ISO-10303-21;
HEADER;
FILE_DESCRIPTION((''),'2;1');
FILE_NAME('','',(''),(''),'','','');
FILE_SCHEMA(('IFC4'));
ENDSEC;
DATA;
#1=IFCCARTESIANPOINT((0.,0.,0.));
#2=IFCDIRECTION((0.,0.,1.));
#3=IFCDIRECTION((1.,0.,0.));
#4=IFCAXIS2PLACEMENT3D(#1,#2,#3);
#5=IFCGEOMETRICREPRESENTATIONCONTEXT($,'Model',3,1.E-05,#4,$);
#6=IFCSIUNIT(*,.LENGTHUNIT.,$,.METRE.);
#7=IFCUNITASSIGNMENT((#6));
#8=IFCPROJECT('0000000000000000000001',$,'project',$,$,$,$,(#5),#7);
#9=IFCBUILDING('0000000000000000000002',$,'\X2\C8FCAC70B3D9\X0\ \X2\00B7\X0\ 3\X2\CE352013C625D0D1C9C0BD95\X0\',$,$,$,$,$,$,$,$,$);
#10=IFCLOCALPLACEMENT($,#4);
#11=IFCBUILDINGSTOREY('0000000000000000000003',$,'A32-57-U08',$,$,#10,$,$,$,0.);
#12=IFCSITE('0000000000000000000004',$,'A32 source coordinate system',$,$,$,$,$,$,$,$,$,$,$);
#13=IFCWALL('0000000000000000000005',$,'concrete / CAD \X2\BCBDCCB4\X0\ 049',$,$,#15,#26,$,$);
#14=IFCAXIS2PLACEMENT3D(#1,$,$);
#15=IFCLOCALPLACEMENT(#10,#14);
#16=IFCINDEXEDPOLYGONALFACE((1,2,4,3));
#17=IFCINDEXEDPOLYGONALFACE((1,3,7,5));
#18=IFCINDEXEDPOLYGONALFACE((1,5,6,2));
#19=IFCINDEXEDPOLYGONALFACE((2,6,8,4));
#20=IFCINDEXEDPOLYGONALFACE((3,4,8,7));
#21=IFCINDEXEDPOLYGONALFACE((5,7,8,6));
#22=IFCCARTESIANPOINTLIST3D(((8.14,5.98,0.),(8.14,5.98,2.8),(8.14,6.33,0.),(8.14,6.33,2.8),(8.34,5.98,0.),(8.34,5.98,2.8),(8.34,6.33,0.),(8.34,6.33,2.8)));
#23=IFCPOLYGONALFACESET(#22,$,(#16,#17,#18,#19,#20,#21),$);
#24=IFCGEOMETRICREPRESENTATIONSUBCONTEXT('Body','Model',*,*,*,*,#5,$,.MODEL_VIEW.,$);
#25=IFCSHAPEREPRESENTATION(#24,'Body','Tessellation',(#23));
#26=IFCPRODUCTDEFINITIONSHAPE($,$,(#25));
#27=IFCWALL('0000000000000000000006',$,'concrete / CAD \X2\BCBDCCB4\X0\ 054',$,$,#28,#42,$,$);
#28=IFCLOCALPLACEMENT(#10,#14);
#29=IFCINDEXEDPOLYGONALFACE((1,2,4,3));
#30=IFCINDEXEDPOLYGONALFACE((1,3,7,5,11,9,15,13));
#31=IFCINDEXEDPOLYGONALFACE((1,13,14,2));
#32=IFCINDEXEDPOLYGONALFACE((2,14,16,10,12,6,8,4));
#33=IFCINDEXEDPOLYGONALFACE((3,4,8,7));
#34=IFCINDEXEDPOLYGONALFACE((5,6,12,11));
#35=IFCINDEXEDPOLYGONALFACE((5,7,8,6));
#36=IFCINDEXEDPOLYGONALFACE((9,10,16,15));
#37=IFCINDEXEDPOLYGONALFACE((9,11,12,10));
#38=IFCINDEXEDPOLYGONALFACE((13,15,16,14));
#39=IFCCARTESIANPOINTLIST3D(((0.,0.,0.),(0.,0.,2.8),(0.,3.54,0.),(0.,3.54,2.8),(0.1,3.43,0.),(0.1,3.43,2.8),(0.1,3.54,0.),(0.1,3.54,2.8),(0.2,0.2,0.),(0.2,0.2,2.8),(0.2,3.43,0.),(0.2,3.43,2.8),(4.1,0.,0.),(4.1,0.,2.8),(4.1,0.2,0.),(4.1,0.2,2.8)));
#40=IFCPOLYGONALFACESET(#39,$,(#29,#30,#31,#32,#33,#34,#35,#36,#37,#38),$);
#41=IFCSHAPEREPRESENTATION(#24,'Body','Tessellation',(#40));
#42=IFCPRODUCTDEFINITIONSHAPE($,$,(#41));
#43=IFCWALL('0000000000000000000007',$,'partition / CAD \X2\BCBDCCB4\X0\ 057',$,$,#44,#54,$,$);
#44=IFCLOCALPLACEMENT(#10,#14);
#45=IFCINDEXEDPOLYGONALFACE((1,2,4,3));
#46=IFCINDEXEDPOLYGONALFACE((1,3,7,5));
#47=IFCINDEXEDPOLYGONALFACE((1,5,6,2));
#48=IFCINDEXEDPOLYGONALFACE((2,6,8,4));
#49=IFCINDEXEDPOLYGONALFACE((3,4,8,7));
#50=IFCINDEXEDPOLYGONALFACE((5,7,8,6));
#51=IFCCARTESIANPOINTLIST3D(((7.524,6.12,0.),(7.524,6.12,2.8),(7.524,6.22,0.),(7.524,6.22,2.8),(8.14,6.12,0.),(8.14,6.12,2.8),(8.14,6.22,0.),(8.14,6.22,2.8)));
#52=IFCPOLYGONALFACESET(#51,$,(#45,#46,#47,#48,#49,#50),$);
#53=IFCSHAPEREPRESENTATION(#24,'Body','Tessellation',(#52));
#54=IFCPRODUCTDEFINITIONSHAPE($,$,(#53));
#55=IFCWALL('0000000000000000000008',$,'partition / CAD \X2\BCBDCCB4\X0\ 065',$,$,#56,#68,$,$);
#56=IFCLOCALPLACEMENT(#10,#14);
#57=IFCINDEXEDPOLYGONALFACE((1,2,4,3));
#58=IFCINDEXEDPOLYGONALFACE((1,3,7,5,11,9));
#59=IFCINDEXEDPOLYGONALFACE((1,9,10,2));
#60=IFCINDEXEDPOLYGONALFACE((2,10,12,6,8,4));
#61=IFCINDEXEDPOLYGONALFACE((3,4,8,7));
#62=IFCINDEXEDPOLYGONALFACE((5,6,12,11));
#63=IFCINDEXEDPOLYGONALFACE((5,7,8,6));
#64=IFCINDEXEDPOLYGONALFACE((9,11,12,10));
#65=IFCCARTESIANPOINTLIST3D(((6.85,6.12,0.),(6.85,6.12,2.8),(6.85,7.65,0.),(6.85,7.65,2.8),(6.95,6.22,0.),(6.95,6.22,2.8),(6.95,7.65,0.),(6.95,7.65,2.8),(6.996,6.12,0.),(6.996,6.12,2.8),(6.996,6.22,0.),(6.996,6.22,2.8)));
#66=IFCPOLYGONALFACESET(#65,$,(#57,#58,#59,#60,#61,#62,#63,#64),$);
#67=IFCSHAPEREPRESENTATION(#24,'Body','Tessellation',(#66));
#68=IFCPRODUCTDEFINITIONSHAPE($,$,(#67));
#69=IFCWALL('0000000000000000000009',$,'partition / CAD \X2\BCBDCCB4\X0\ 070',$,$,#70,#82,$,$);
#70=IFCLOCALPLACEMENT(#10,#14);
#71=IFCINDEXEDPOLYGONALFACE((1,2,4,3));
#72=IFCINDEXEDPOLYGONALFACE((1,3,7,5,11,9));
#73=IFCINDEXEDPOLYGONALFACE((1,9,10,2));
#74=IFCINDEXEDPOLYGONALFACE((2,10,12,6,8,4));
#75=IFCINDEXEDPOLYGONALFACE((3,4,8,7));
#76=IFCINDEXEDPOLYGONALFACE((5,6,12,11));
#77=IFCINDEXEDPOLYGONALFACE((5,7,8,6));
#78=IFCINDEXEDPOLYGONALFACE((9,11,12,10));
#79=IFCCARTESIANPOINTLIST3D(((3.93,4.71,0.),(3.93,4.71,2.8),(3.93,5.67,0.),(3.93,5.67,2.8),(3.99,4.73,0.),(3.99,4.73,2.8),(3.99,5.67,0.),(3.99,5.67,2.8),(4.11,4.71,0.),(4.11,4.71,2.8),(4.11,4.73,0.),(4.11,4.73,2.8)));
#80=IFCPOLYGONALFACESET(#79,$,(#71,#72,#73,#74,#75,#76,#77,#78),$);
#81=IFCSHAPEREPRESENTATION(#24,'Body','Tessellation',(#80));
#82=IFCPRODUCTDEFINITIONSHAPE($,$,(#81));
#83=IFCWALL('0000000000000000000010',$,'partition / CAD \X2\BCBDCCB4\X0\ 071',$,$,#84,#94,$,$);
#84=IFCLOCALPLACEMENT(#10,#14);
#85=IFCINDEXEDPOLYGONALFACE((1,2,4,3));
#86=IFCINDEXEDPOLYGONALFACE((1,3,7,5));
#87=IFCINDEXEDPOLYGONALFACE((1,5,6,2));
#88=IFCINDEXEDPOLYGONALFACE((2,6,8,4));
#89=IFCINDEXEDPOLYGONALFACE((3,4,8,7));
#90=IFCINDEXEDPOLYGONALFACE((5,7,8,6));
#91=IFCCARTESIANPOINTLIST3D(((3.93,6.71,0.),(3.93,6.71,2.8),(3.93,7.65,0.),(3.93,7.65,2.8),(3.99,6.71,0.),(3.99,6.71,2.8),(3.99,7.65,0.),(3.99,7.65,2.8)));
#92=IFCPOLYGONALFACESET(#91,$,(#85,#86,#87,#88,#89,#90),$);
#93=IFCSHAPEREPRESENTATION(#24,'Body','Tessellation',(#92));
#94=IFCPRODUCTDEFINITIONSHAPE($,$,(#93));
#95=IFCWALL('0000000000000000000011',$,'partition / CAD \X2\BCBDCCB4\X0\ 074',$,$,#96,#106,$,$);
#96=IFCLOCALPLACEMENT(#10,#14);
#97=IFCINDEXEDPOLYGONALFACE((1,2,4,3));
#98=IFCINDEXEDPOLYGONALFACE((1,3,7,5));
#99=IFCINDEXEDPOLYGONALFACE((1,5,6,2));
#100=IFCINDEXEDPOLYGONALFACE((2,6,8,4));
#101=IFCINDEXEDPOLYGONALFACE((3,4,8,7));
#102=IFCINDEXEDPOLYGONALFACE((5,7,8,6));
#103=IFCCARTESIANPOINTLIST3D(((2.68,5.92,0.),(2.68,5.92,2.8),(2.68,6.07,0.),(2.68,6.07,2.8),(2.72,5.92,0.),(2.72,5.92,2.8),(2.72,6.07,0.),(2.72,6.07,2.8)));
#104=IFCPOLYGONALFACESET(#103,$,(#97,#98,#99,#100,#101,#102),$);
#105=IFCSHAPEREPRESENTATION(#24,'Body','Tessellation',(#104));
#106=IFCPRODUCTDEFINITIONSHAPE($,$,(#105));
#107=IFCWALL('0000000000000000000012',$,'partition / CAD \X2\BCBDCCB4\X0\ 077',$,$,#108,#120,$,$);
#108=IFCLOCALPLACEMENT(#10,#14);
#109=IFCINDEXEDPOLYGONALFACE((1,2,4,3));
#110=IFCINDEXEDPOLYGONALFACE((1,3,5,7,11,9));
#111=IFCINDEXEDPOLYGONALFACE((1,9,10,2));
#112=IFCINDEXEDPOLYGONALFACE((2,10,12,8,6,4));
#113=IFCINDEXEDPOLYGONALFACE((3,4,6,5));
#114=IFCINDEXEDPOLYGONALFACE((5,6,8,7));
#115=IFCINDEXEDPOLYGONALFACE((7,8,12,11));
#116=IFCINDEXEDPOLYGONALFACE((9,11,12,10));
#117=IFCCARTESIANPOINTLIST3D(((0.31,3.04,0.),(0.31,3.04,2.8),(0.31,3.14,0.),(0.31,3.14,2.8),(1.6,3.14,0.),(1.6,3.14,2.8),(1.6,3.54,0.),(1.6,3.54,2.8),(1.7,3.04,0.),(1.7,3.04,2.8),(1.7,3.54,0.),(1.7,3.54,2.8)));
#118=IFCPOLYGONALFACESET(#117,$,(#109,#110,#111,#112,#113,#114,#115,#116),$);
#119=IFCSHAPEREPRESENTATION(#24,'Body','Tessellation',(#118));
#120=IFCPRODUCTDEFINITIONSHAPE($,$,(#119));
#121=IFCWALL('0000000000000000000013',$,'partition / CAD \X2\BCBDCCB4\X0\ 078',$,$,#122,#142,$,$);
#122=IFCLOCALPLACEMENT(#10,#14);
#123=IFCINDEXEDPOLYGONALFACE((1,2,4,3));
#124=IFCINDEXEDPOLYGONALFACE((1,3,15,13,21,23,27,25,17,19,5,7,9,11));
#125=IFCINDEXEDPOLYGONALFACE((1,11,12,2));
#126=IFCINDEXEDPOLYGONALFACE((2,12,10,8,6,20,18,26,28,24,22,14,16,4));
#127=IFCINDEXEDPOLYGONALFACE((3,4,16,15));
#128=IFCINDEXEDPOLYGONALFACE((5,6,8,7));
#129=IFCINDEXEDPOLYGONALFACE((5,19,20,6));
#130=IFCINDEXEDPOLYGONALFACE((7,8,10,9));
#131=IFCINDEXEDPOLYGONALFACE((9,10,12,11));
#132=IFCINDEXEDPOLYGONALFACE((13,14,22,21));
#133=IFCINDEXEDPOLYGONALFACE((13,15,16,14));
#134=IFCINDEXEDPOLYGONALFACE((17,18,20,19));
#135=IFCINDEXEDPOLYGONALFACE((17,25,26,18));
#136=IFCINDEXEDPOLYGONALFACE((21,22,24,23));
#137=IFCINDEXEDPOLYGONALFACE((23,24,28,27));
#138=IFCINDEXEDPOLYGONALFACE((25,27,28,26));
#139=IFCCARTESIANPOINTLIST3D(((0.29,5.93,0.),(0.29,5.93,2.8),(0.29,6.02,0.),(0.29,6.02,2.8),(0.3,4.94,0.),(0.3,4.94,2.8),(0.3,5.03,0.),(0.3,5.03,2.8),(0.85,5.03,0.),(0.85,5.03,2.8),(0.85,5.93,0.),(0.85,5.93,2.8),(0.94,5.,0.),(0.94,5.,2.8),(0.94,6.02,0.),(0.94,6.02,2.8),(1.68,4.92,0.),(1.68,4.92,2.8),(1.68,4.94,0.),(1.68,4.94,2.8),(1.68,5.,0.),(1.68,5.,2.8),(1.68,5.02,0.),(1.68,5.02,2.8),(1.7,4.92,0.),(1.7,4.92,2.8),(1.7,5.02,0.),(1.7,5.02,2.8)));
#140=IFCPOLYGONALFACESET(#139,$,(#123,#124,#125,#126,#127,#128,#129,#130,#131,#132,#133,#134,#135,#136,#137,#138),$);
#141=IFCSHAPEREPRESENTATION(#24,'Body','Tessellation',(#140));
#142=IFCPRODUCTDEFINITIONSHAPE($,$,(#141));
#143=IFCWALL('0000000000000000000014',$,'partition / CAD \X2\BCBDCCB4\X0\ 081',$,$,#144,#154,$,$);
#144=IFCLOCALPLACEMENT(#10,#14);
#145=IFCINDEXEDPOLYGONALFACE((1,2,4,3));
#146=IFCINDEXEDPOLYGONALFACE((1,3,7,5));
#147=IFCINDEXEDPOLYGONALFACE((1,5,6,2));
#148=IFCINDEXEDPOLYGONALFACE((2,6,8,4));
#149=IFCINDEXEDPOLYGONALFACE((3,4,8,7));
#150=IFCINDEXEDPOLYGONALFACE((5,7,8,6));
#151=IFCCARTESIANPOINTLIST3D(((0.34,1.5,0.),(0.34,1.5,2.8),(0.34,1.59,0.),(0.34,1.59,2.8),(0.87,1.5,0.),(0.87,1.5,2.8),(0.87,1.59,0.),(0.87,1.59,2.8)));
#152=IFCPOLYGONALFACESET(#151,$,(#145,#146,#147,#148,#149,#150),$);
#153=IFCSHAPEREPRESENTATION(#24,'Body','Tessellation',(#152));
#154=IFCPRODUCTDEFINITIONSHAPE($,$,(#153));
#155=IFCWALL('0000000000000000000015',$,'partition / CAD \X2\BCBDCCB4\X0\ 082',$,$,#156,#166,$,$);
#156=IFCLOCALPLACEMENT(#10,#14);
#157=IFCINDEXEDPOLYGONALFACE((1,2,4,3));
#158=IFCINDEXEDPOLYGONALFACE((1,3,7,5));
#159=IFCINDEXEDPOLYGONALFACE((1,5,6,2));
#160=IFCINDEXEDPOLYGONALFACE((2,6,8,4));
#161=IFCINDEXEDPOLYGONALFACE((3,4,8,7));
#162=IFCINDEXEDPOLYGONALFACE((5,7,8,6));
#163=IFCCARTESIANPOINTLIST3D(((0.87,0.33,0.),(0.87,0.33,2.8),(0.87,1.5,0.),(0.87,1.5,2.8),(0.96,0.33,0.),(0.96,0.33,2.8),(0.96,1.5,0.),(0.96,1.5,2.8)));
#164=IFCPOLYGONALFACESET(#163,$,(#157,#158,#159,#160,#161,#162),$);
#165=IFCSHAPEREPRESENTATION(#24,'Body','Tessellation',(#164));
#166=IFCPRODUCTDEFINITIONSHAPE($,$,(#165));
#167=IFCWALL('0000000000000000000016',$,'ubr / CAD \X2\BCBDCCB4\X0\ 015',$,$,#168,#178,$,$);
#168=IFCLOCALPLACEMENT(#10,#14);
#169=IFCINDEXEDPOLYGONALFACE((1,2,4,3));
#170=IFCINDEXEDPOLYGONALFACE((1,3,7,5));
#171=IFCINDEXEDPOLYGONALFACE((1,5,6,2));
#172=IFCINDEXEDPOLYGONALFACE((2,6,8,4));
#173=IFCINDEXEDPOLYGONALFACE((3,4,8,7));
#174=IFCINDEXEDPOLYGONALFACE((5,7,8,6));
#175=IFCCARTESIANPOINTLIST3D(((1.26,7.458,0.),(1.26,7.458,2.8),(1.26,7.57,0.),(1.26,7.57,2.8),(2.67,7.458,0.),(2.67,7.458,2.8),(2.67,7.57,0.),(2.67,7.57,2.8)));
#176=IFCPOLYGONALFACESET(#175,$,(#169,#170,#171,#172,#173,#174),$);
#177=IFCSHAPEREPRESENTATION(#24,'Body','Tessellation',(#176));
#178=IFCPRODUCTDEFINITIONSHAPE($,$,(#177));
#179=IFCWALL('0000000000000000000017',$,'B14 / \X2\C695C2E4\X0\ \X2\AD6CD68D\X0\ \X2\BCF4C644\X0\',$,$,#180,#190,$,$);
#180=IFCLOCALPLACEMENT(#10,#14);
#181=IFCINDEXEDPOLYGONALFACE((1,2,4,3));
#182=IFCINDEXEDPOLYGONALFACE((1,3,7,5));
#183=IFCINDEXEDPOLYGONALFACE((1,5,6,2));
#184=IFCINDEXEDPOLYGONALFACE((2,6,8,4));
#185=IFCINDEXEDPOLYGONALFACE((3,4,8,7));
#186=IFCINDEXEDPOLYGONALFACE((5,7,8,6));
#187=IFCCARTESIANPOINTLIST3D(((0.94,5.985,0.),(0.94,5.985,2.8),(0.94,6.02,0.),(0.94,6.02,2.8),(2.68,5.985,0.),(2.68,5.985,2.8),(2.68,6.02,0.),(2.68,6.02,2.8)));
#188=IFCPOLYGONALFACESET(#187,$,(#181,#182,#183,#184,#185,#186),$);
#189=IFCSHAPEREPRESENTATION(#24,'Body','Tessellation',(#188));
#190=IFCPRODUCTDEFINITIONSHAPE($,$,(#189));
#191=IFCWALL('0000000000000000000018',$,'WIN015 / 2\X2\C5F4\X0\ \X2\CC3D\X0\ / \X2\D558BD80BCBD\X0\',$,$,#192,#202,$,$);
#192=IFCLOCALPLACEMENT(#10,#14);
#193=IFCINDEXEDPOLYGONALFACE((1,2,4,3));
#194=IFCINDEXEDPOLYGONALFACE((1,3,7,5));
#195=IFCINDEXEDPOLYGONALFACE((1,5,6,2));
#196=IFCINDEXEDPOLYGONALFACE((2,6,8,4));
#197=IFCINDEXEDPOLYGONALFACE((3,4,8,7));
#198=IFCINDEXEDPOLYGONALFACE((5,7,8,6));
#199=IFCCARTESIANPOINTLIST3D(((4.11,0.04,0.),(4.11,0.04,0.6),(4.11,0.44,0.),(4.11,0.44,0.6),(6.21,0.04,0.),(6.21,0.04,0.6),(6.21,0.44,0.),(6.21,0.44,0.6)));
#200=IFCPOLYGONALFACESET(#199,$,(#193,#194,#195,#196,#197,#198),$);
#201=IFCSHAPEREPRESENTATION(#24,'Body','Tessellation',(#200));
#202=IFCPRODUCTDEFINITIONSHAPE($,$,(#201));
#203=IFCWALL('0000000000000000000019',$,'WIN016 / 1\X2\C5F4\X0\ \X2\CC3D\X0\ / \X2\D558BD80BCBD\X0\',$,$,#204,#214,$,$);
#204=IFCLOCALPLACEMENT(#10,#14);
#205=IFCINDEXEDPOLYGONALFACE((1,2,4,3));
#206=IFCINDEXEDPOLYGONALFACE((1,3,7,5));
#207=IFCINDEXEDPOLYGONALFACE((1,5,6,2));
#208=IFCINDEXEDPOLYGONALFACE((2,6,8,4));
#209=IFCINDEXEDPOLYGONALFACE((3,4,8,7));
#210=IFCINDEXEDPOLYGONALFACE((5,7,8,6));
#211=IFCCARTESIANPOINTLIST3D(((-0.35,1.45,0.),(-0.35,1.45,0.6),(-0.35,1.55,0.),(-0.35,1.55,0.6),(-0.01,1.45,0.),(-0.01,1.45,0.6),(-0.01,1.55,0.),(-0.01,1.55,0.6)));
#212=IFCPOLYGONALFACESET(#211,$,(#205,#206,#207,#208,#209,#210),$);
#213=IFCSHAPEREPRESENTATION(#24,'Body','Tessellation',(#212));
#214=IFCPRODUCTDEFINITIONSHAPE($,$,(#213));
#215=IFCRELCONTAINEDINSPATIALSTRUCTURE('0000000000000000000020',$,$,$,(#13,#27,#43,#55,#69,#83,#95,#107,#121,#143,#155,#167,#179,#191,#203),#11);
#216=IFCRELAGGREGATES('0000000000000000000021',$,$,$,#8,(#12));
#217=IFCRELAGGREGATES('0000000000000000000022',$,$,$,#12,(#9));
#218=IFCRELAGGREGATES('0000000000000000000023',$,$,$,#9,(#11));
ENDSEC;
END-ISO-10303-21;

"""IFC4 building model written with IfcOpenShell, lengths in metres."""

from ifc_helpers import new_model, si_unit, origin, origin_with_axes, place, context, subcontext, project, spatial, polyline, outline, extrude, element, save


model = new_model("IFC4")

# Units and contexts
model_context = context("Model", 3, precision=1e-05, world=origin_with_axes())
body_context = subcontext(model_context, "Body", "Model", "MODEL_VIEW")
ifc_project = project(units=[si_unit("LENGTHUNIT", "METRE")], contexts=[model_context])

# Site, building, storey
site = spatial("IfcSite", under=ifc_project, Name="A32 source coordinate system")
building = spatial("IfcBuilding", under=site, Name="주거동 · 3층–옥탑지붕")
storey_placement = place(None, origin_with_axes())
storey = spatial("IfcBuildingStorey", under=building, at=storey_placement, Name="A32-57-U08", Elevation=0.0)

# Walls
wall_1_placement = place(storey_placement, origin_with_axes())
element("IfcWall", 1, at=wall_1_placement, inside=storey, Name="concrete / CAD 벽체 049", context=body_context, shape_type="SweptSolid", body=[
    extrude(outline(polyline([(8.34, 6.33), (8.34, 5.98), (8.14, 5.98), (8.14, 6.33), (8.34, 6.33)])), origin(), (0.0, 0.0, 1.0), 2.8),
])
wall_2_placement = place(storey_placement, origin_with_axes())
element("IfcWall", 2, at=wall_2_placement, inside=storey, Name="concrete / CAD 벽체 054", context=body_context, shape_type="SweptSolid", body=[
    extrude(outline(polyline([(0.1, 3.54), (0.1, 3.43), (0.2, 3.43), (0.2, 0.2), (4.1, 0.2), (4.1, 0.0), (0.0, 0.0), (0.0, 3.54), (0.1, 3.54)])), origin(), (0.0, 0.0, 1.0), 2.8),
])
wall_3_placement = place(storey_placement, origin_with_axes())
element("IfcWall", 3, at=wall_3_placement, inside=storey, Name="partition / CAD 벽체 057", context=body_context, shape_type="SweptSolid", body=[
    extrude(outline(polyline([(7.524, 6.22), (8.14, 6.22), (8.14, 6.12), (7.524, 6.12), (7.524, 6.22)])), origin(), (0.0, 0.0, 1.0), 2.8),
])
wall_4_placement = place(storey_placement, origin_with_axes())
element("IfcWall", 4, at=wall_4_placement, inside=storey, Name="partition / CAD 벽체 065", context=body_context, shape_type="SweptSolid", body=[
    extrude(outline(polyline([(6.95, 7.65), (6.95, 6.22), (6.996, 6.22), (6.996, 6.12), (6.85, 6.12), (6.85, 7.65), (6.95, 7.65)])), origin(), (0.0, 0.0, 1.0), 2.8),
])
wall_5_placement = place(storey_placement, origin_with_axes())
element("IfcWall", 5, at=wall_5_placement, inside=storey, Name="partition / CAD 벽체 070", context=body_context, shape_type="SweptSolid", body=[
    extrude(outline(polyline([(4.11, 4.73), (4.11, 4.71), (3.93, 4.71), (3.93, 5.67), (3.99, 5.67), (3.99, 4.73), (4.11, 4.73)])), origin(), (0.0, 0.0, 1.0), 2.8),
])
wall_6_placement = place(storey_placement, origin_with_axes())
element("IfcWall", 6, at=wall_6_placement, inside=storey, Name="partition / CAD 벽체 071", context=body_context, shape_type="SweptSolid", body=[
    extrude(outline(polyline([(3.93, 6.71), (3.93, 7.65), (3.99, 7.65), (3.99, 6.71), (3.93, 6.71)])), origin(), (0.0, 0.0, 1.0), 2.8),
])
wall_7_placement = place(storey_placement, origin_with_axes())
element("IfcWall", 7, at=wall_7_placement, inside=storey, Name="partition / CAD 벽체 074", context=body_context, shape_type="SweptSolid", body=[
    extrude(outline(polyline([(2.72, 6.07), (2.72, 5.92), (2.68, 5.92), (2.68, 6.07), (2.72, 6.07)])), origin(), (0.0, 0.0, 1.0), 2.8),
])
wall_8_placement = place(storey_placement, origin_with_axes())
element("IfcWall", 8, at=wall_8_placement, inside=storey, Name="partition / CAD 벽체 077", context=body_context, shape_type="SweptSolid", body=[
    extrude(outline(polyline([(1.7, 3.54), (1.7, 3.04), (0.31, 3.04), (0.31, 3.14), (1.6, 3.14), (1.6, 3.54), (1.7, 3.54)])), origin(), (0.0, 0.0, 1.0), 2.8),
])
wall_9_placement = place(storey_placement, origin_with_axes())
element("IfcWall", 9, at=wall_9_placement, inside=storey, Name="partition / CAD 벽체 078", context=body_context, shape_type="SweptSolid", body=[
    extrude(outline(polyline([(1.7, 4.92), (1.68, 4.92), (1.68, 4.94), (0.3, 4.94), (0.3, 5.03), (0.85, 5.03), (0.85, 5.93), (0.29, 5.93), (0.29, 6.02), (0.94, 6.02), (0.94, 5.0), (1.68, 5.0), (1.68, 5.02), (1.7, 5.02), (1.7, 4.92)])), origin(), (0.0, 0.0, 1.0), 2.8),
])
wall_10_placement = place(storey_placement, origin_with_axes())
element("IfcWall", 10, at=wall_10_placement, inside=storey, Name="partition / CAD 벽체 081", context=body_context, shape_type="SweptSolid", body=[
    extrude(outline(polyline([(0.34, 1.59), (0.87, 1.59), (0.87, 1.5), (0.34, 1.5), (0.34, 1.59)])), origin(), (0.0, 0.0, 1.0), 2.8),
])
wall_11_placement = place(storey_placement, origin_with_axes())
element("IfcWall", 11, at=wall_11_placement, inside=storey, Name="partition / CAD 벽체 082", context=body_context, shape_type="SweptSolid", body=[
    extrude(outline(polyline([(0.96, 0.33), (0.87, 0.33), (0.87, 1.5), (0.96, 1.5), (0.96, 0.33)])), origin(), (0.0, 0.0, 1.0), 2.8),
])
wall_12_placement = place(storey_placement, origin_with_axes())
element("IfcWall", 12, at=wall_12_placement, inside=storey, Name="ubr / CAD 벽체 015", context=body_context, shape_type="SweptSolid", body=[
    extrude(outline(polyline([(2.67, 7.57), (2.67, 7.458), (1.26, 7.458), (1.26, 7.57), (2.67, 7.57)])), origin(), (0.0, 0.0, 1.0), 2.8),
])
wall_13_placement = place(storey_placement, origin_with_axes())
element("IfcWall", 13, at=wall_13_placement, inside=storey, Name="B14 / 욕실 구획 보완", context=body_context, shape_type="SweptSolid", body=[
    extrude(outline(polyline([(2.68, 5.985), (0.94, 5.985), (0.94, 6.02), (2.68, 6.02), (2.68, 5.985)])), origin(), (0.0, 0.0, 1.0), 2.8),
])
wall_14_placement = place(storey_placement, origin_with_axes())
element("IfcWall", 14, at=wall_14_placement, inside=storey, Name="WIN015 / 2열 창 / 하부벽", context=body_context, shape_type="SweptSolid", body=[
    extrude(outline(polyline([(4.11, 0.04), (4.11, 0.44), (6.21, 0.44), (6.21, 0.04), (4.11, 0.04)])), origin(), (0.0, 0.0, 1.0), 0.6),
])
wall_15_placement = place(storey_placement, origin_with_axes())
element("IfcWall", 15, at=wall_15_placement, inside=storey, Name="WIN016 / 1열 창 / 하부벽", context=body_context, shape_type="SweptSolid", body=[
    extrude(outline(polyline([(-0.35, 1.45), (-0.35, 1.55), (-0.01, 1.55), (-0.01, 1.45), (-0.35, 1.45)])), origin(), (0.0, 0.0, 1.0), 0.6),
])

save(model, "model.ifc")
